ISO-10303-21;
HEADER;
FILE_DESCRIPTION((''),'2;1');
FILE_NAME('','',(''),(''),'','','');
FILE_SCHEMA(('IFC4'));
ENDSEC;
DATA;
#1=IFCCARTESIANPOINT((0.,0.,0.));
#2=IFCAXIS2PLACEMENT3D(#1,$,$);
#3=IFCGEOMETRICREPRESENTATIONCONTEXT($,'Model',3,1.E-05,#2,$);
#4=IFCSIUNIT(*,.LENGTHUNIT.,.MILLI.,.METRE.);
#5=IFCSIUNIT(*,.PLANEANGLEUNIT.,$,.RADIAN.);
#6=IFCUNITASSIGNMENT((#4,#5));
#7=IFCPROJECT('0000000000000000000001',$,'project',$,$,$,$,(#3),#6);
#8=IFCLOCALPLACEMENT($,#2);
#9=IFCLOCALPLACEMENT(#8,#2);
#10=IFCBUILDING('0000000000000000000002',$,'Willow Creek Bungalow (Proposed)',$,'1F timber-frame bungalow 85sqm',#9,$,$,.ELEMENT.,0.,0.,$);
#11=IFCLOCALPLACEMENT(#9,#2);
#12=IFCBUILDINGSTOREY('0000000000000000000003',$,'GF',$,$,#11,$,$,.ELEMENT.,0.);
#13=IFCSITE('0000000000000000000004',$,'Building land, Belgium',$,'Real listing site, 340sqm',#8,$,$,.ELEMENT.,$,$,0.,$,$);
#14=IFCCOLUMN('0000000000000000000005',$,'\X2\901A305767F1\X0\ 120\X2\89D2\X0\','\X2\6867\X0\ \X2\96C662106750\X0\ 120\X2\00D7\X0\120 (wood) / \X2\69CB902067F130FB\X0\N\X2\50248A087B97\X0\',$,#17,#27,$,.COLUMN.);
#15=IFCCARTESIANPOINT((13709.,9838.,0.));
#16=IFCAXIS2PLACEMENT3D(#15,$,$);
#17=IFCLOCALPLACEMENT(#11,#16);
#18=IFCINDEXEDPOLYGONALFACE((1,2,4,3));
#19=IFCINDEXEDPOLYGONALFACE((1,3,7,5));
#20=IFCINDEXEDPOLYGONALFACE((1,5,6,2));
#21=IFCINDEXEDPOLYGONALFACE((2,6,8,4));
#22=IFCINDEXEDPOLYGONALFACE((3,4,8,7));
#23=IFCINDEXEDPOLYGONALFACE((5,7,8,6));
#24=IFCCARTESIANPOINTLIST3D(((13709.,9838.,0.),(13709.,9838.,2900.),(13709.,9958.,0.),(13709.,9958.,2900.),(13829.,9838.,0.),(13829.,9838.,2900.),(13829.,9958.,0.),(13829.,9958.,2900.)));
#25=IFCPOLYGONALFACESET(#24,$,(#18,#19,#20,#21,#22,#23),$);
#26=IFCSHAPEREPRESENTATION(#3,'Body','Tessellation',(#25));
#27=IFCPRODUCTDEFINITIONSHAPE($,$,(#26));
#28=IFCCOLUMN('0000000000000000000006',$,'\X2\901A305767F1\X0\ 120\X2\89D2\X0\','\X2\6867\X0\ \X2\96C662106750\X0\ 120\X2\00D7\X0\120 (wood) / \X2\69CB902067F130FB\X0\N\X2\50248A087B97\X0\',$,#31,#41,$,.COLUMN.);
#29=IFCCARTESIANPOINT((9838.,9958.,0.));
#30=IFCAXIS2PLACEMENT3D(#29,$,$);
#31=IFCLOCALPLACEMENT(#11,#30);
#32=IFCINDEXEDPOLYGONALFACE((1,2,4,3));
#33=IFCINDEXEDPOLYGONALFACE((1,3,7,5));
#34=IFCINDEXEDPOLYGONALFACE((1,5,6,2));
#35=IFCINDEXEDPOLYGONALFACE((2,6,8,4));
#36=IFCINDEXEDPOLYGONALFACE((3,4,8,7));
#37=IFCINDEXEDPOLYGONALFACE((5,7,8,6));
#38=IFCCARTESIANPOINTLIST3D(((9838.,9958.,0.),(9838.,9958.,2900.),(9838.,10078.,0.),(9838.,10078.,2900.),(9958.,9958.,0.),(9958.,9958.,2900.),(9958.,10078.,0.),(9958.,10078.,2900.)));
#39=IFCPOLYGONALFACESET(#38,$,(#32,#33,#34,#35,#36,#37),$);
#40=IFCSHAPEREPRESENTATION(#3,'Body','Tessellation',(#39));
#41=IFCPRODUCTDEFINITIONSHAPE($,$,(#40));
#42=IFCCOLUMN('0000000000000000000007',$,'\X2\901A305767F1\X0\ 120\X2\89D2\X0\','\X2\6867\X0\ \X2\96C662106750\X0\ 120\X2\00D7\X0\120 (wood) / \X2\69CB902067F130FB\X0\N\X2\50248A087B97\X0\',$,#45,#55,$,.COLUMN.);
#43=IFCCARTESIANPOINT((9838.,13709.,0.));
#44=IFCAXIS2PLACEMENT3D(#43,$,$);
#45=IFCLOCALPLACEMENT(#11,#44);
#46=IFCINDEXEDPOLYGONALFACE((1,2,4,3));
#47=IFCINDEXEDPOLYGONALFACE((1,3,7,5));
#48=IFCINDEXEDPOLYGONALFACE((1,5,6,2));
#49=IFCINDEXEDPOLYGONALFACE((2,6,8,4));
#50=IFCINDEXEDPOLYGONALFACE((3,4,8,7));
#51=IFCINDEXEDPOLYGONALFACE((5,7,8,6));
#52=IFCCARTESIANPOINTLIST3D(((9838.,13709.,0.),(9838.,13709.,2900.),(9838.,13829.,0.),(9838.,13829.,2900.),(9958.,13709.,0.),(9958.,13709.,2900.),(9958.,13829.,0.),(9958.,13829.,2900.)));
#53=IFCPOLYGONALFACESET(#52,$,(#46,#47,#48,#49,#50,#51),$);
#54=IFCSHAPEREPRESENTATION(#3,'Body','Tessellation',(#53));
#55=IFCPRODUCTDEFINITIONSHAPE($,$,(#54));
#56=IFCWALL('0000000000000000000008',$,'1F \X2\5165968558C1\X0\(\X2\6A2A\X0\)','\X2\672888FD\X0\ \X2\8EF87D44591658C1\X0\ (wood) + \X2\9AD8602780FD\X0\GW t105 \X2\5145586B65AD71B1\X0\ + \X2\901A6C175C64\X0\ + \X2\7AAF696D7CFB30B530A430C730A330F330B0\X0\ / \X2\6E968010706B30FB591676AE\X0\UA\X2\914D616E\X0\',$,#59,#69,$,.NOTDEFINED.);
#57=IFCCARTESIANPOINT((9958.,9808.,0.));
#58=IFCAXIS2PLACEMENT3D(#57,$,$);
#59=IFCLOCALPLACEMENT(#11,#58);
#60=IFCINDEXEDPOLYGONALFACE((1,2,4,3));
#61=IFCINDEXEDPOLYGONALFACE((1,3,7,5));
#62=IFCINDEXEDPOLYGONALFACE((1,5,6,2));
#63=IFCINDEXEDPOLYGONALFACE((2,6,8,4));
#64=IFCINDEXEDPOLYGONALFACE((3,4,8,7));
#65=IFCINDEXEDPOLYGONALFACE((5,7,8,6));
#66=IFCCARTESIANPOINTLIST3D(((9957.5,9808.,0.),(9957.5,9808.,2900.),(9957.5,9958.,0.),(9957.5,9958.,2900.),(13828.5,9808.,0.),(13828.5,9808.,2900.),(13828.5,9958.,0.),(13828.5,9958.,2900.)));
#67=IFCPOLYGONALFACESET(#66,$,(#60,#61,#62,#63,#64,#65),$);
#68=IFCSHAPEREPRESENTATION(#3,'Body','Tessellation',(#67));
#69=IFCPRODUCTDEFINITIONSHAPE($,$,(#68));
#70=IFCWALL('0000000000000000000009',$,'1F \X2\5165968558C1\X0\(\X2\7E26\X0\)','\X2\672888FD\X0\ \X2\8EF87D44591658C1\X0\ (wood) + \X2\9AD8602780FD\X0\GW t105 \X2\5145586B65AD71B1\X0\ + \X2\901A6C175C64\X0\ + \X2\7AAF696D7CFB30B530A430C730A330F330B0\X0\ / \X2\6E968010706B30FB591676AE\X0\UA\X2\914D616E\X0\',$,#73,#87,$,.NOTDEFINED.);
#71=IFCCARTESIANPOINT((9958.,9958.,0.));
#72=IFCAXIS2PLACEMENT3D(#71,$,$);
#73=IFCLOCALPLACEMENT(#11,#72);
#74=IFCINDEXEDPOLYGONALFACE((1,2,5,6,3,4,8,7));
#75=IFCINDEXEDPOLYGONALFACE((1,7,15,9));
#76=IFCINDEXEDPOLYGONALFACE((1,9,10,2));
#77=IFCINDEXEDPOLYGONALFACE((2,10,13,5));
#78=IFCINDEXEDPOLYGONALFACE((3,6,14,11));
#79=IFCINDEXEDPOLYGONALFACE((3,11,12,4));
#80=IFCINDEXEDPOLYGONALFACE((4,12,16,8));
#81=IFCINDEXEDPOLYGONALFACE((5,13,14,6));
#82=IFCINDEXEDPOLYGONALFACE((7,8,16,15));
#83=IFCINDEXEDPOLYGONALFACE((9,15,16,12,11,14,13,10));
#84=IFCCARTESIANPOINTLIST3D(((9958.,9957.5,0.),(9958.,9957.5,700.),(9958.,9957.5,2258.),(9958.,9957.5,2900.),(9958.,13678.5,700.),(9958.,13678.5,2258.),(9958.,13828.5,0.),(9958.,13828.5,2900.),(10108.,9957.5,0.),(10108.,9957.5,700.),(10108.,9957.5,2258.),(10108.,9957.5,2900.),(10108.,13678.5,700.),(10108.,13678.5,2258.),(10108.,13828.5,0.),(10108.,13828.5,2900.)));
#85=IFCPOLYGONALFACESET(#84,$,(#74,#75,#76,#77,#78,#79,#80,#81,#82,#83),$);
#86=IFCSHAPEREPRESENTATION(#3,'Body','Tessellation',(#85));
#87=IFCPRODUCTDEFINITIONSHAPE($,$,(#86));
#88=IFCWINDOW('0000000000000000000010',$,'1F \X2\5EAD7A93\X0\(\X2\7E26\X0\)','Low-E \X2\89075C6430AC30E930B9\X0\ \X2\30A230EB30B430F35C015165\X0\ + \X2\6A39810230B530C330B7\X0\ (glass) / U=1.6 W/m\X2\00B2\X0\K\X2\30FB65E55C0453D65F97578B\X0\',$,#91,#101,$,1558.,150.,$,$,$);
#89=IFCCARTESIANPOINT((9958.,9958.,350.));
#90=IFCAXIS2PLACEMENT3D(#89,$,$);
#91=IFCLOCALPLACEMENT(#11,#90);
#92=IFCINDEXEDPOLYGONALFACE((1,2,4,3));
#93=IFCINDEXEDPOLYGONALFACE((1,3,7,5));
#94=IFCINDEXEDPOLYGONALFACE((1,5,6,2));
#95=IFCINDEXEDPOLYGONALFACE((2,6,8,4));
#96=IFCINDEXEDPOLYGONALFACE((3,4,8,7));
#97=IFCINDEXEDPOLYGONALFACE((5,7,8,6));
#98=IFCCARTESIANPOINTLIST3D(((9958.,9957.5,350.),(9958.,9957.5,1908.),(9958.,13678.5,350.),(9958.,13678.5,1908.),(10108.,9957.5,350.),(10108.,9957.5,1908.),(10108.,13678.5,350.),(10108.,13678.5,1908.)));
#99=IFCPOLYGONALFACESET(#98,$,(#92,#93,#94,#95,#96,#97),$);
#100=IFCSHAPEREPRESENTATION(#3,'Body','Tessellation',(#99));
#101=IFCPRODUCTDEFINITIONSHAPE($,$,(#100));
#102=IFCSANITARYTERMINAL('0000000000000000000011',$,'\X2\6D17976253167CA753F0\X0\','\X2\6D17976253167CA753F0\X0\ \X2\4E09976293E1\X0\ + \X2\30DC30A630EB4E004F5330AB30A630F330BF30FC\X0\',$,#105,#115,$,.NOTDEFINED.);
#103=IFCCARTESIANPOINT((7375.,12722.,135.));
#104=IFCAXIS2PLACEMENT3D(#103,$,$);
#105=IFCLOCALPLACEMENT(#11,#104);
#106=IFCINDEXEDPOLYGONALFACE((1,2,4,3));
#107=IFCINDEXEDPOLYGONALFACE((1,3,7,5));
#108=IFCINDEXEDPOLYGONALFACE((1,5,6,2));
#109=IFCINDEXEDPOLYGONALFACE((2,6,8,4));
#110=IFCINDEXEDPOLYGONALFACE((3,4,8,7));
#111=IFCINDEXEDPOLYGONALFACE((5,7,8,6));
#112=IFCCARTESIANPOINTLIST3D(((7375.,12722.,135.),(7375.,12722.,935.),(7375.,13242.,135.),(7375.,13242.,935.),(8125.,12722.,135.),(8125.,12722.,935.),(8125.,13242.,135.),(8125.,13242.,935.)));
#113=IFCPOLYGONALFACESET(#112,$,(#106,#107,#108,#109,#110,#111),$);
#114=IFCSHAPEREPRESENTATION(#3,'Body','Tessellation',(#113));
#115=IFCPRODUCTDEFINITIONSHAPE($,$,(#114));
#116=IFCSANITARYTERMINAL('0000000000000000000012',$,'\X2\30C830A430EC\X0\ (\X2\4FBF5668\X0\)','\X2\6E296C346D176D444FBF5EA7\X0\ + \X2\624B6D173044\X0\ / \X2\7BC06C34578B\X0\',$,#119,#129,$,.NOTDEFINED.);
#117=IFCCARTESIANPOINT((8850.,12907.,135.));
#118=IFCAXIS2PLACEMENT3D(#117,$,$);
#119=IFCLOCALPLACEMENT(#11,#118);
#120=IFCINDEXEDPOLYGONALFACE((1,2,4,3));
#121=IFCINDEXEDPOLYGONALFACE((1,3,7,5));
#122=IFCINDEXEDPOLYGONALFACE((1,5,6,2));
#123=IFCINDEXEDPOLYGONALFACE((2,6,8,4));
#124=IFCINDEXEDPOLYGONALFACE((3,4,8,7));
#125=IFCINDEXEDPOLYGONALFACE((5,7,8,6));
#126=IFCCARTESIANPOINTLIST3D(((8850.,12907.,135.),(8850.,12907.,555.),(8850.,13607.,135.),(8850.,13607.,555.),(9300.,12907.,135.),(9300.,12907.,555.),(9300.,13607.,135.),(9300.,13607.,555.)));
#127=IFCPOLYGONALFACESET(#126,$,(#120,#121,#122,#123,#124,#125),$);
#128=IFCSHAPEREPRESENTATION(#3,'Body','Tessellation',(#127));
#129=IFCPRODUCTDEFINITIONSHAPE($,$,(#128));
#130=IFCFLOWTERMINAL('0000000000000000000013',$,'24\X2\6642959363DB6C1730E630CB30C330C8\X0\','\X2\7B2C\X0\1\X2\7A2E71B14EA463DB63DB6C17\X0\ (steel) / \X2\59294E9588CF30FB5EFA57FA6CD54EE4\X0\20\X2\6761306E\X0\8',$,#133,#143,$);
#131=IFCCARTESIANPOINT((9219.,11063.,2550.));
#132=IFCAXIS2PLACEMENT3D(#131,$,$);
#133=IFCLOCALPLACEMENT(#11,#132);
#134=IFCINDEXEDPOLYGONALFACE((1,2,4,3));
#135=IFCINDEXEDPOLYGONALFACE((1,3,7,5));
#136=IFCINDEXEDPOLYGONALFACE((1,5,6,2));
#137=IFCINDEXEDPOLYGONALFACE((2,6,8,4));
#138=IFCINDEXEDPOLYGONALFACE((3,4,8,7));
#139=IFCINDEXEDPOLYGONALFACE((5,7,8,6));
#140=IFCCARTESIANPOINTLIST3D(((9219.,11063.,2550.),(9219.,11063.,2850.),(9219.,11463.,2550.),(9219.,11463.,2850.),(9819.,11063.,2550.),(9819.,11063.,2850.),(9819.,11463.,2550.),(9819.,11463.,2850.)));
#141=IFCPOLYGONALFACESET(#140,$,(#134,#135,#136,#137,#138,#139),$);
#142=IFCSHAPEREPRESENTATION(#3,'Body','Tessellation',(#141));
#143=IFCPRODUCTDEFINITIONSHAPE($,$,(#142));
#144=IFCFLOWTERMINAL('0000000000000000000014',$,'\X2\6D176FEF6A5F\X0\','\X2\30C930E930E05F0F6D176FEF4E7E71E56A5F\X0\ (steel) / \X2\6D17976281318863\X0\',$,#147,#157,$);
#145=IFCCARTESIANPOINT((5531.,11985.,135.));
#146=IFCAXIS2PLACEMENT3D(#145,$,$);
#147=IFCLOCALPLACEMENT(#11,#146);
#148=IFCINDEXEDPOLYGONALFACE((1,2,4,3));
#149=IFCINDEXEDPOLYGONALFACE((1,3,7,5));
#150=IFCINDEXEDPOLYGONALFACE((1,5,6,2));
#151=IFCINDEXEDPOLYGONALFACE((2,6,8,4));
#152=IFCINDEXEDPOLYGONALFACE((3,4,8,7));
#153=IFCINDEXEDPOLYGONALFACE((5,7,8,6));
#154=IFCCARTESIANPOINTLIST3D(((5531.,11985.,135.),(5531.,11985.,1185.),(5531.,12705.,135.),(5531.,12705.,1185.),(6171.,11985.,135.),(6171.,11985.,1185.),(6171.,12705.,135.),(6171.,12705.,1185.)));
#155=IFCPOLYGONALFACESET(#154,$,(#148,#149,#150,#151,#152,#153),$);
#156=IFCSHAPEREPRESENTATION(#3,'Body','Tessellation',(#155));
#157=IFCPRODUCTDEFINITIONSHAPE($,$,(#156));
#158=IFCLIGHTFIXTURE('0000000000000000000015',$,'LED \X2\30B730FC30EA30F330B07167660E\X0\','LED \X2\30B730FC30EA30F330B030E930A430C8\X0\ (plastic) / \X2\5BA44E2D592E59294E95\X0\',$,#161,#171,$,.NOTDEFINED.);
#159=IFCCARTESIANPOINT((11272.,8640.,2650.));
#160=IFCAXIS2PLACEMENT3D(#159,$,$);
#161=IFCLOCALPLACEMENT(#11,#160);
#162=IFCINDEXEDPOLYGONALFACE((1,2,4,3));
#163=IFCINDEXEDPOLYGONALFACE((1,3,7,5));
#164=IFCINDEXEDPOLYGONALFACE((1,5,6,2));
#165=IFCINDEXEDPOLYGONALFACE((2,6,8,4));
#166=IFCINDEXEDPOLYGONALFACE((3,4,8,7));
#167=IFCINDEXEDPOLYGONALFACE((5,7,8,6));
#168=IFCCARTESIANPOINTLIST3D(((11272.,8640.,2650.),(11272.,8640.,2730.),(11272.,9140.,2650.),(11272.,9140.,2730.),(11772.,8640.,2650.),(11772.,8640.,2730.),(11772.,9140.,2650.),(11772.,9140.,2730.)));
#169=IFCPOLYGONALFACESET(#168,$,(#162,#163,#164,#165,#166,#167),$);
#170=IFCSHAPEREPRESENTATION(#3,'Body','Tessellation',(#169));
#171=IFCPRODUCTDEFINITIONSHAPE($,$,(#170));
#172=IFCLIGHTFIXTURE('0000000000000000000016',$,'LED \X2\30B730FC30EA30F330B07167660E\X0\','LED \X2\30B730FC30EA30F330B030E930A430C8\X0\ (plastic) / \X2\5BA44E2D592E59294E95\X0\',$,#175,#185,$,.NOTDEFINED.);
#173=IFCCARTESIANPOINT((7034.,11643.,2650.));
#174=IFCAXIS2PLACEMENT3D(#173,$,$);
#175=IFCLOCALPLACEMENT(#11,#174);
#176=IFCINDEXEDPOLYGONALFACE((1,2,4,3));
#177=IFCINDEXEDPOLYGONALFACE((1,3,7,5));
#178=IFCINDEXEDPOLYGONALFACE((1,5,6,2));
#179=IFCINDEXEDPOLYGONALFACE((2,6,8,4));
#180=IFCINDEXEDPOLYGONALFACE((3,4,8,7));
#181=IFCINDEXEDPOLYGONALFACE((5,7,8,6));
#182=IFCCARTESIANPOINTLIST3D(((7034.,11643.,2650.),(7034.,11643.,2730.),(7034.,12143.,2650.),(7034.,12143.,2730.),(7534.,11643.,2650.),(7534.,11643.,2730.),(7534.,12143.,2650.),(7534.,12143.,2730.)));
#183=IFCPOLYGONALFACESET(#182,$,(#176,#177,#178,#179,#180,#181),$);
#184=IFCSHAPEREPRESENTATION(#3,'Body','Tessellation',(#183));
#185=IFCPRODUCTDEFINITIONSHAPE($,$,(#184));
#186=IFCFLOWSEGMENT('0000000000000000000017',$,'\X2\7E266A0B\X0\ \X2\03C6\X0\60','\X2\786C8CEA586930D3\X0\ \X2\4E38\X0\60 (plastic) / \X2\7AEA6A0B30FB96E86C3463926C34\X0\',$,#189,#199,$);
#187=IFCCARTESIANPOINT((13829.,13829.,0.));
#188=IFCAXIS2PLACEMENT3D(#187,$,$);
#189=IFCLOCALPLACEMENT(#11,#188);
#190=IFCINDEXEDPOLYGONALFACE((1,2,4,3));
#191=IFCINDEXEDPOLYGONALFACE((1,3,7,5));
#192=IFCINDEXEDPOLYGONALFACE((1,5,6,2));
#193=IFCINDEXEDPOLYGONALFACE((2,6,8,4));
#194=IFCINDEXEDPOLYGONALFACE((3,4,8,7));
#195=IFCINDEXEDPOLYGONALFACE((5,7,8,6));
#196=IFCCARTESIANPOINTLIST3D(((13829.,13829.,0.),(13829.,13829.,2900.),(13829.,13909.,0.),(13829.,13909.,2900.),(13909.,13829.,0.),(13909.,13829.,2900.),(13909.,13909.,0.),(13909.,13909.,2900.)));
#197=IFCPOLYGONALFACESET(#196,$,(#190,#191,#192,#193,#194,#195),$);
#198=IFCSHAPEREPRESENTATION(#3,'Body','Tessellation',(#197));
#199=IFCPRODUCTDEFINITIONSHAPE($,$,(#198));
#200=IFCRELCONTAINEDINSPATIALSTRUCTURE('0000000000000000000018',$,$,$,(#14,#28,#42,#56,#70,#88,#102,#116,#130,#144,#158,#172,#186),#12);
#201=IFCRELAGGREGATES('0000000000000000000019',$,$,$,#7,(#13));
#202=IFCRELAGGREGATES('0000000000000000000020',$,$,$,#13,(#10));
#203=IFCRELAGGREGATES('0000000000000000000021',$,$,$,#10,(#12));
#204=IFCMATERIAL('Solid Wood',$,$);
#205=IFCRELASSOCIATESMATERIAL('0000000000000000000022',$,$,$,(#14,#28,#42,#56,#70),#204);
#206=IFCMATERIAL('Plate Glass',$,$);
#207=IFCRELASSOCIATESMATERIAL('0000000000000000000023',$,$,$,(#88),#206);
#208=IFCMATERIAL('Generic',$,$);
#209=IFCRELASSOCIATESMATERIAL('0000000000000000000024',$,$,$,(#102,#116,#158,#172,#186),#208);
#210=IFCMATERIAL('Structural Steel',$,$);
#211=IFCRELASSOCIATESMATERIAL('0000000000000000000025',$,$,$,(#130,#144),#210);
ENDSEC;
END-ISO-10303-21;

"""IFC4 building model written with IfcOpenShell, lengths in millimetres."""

from ifc_helpers import new_model, si_unit, frame, frame_2d, origin, place, context, project, spatial, rectangle, extrude, material, element, fill, save


model = new_model("IFC4")

# Units and contexts
model_context = context("Model", 3, precision=1e-05, world=origin())
ifc_project = project(units=[si_unit("LENGTHUNIT", "METRE", prefix="MILLI"), si_unit("PLANEANGLEUNIT", "RADIAN")], contexts=[model_context])

# Site, building, storey
site_placement = place(None, origin())
site = spatial("IfcSite", under=ifc_project, at=site_placement, Name="Building land, Belgium", ObjectType="Real listing site, 340sqm", CompositionType="ELEMENT", RefElevation=0.0)
building_placement = place(site_placement, origin())
building = spatial("IfcBuilding", under=site, at=building_placement, Name="Willow Creek Bungalow (Proposed)", ObjectType="1F timber-frame bungalow 85sqm", CompositionType="ELEMENT", ElevationOfRefHeight=0.0, ElevationOfTerrain=0.0)
storey_placement = place(building_placement, origin())
storey = spatial("IfcBuildingStorey", under=building, at=storey_placement, Name="GF", CompositionType="ELEMENT", Elevation=0.0)

# Columns
ifc_material_1 = material(Name="Solid Wood")
column_1_placement = place(storey_placement, frame((13709.0, 9838.0, 0.0)))
element("IfcColumn", 1, at=column_1_placement, inside=storey, material=ifc_material_1, Name="通し柱 120角", Description="桧 集成材 120×120 (wood) / 構造柱・N値計算", PredefinedType="COLUMN", context=model_context, shape_type="SweptSolid", body=[
    extrude(rectangle(XDim=120.0, YDim=120.0, at=frame_2d((60.0, 60.0))), frame((13709.0, 9838.0, 0.0)), (0.0, 0.0, 1.0), 2900.0),
])
column_2_placement = place(storey_placement, frame((9838.0, 9958.0, 0.0)))
element("IfcColumn", 2, at=column_2_placement, inside=storey, material=ifc_material_1, Name="通し柱 120角", Description="桧 集成材 120×120 (wood) / 構造柱・N値計算", PredefinedType="COLUMN", context=model_context, shape_type="SweptSolid", body=[
    extrude(rectangle(XDim=120.0, YDim=120.0, at=frame_2d((60.0, 60.0))), frame((9838.0, 9958.0, 0.0)), (0.0, 0.0, 1.0), 2900.0),
])
column_3_placement = place(storey_placement, frame((9838.0, 13709.0, 0.0)))
element("IfcColumn", 3, at=column_3_placement, inside=storey, material=ifc_material_1, Name="通し柱 120角", Description="桧 集成材 120×120 (wood) / 構造柱・N値計算", PredefinedType="COLUMN", context=model_context, shape_type="SweptSolid", body=[
    extrude(rectangle(XDim=120.0, YDim=120.0, at=frame_2d((60.0, 60.0))), frame((9838.0, 13709.0, 0.0)), (0.0, 0.0, 1.0), 2900.0),
])

# Wall
wall_1_placement = place(storey_placement, frame((9958.0, 9808.0, 0.0)))
element("IfcWall", 4, at=wall_1_placement, inside=storey, material=ifc_material_1, Name="1F 入隅壁(横)", Description="木製 軸組外壁 (wood) + 高性能GW t105 充填断熱 + 通気層 + 窯業系サイディング / 準耐火・外皮UA配慮", PredefinedType="NOTDEFINED", context=model_context, shape_type="SweptSolid", body=[
    extrude(rectangle(XDim=3871.0, YDim=150.0, at=frame_2d((1935.0, 75.0))), frame((9958.0, 9808.0, 0.0)), (0.0, 0.0, 1.0), 2900.0),
])

# Wall, opening, window
wall_2_placement = place(storey_placement, frame((9958.0, 9958.0, 0.0)))
wall_2 = element("IfcWall", 5, at=wall_2_placement, inside=storey, material=ifc_material_1, Name="1F 入隅壁(縦)", Description="木製 軸組外壁 (wood) + 高性能GW t105 充填断熱 + 通気層 + 窯業系サイディング / 準耐火・外皮UA配慮", PredefinedType="NOTDEFINED", context=model_context, shape_type="SweptSolid", body=[
    extrude(rectangle(XDim=150.0, YDim=3871.0, at=frame_2d((75.0, 1935.0))), frame((9958.0, 9958.0, 0.0)), (0.0, 0.0, 1.0), 2900.0),
])
opening_placement = place(storey_placement, frame((9958.0, 9958.0, 350.0)))
opening = element("IfcOpeningElement", 6, at=opening_placement, cuts=wall_2, PredefinedType="NOTDEFINED", context=model_context, shape_type="SweptSolid", body=[
    extrude(rectangle(XDim=150.0, YDim=3721.0, at=frame_2d((75.0, 1860.0))), frame((9958.0, 9958.0, 350.0)), (0.0, 0.0, 1.0), 1558.0),
])
ifc_material_2 = material(Name="Plate Glass")
window_placement = place(storey_placement, frame((9958.0, 9958.0, 350.0)))
window = element("IfcWindow", 7, at=window_placement, inside=storey, material=ifc_material_2, Name="1F 庭窓(縦)", Description="Low-E 複層ガラス アルゴン封入 + 樹脂サッシ (glass) / U=1.6 W/m²K・日射取得型", OverallHeight=1558.0, OverallWidth=150.0, context=model_context, shape_type="SweptSolid", body=[
    extrude(rectangle(XDim=150.0, YDim=3721.0, at=frame_2d((75.0, 1860.0))), frame((9958.0, 9958.0, 350.0)), (0.0, 0.0, 1.0), 1558.0),
])
fill(opening, window)

# Sanitary terminals
ifc_material_3 = material(Name="Generic")
sanitary_terminal_1_placement = place(storey_placement, frame((7375.0, 12722.0, 135.0)))
element("IfcSanitaryTerminal", 8, at=sanitary_terminal_1_placement, inside=storey, material=ifc_material_3, Name="洗面化粧台", Description="洗面化粧台 三面鏡 + ボウル一体カウンター", PredefinedType="NOTDEFINED", context=model_context, shape_type="SweptSolid", body=[
    extrude(rectangle(XDim=750.0, YDim=520.0, at=frame_2d((375.0, 260.0))), frame((7375.0, 12722.0, 135.0)), (0.0, 0.0, 1.0), 800.0),
])
sanitary_terminal_2_placement = place(storey_placement, frame((8850.0, 12907.0, 135.0)))
element("IfcSanitaryTerminal", 9, at=sanitary_terminal_2_placement, inside=storey, material=ifc_material_3, Name="トイレ (便器)", Description="温水洗浄便座 + 手洗い / 節水型", PredefinedType="NOTDEFINED", context=model_context, shape_type="SweptSolid", body=[
    extrude(rectangle(XDim=450.0, YDim=700.0, at=frame_2d((225.0, 350.0))), frame((8850.0, 12907.0, 135.0)), (0.0, 0.0, 1.0), 420.0),
])

# Flow terminals
ifc_material_4 = material(Name="Structural Steel")
flow_terminal_1_placement = place(storey_placement, frame((9219.0, 11063.0, 2550.0)))
element("IfcFlowTerminal", 10, at=flow_terminal_1_placement, inside=storey, material=ifc_material_4, Name="24時間換気ユニット", Description="第1種熱交換換気 (steel) / 天井裏・建基法令20条の8", context=model_context, shape_type="SweptSolid", body=[
    extrude(rectangle(XDim=600.0, YDim=400.0, at=frame_2d((300.0, 200.0))), frame((9219.0, 11063.0, 2550.0)), (0.0, 0.0, 1.0), 300.0),
])
flow_terminal_2_placement = place(storey_placement, frame((5531.0, 11985.0, 135.0)))
element("IfcFlowTerminal", 11, at=flow_terminal_2_placement, inside=storey, material=ifc_material_4, Name="洗濯機", Description="ドラム式洗濯乾燥機 (steel) / 洗面脱衣", context=model_context, shape_type="SweptSolid", body=[
    extrude(rectangle(XDim=640.0, YDim=720.0, at=frame_2d((320.0, 360.0))), frame((5531.0, 11985.0, 135.0)), (0.0, 0.0, 1.0), 1050.0),
])

# Light fixtures
light_fixture_1_placement = place(storey_placement, frame((11272.0, 8640.0, 2650.0)))
element("IfcLightFixture", 12, at=light_fixture_1_placement, inside=storey, material=ifc_material_3, Name="LED シーリング照明", Description="LED シーリングライト (plastic) / 室中央天井", PredefinedType="NOTDEFINED", context=model_context, shape_type="SweptSolid", body=[
    extrude(rectangle(XDim=500.0, YDim=500.0, at=frame_2d((250.0, 250.0))), frame((11272.0, 8640.0, 2650.0)), (0.0, 0.0, 1.0), 80.0),
])
light_fixture_2_placement = place(storey_placement, frame((7034.0, 11643.0, 2650.0)))
element("IfcLightFixture", 13, at=light_fixture_2_placement, inside=storey, material=ifc_material_3, Name="LED シーリング照明", Description="LED シーリングライト (plastic) / 室中央天井", PredefinedType="NOTDEFINED", context=model_context, shape_type="SweptSolid", body=[
    extrude(rectangle(XDim=500.0, YDim=500.0, at=frame_2d((250.0, 250.0))), frame((7034.0, 11643.0, 2650.0)), (0.0, 0.0, 1.0), 80.0),
])

# Flow segment
flow_segment_placement = place(storey_placement, frame((13829.0, 13829.0, 0.0)))
element("IfcFlowSegment", 14, at=flow_segment_placement, inside=storey, material=ifc_material_3, Name="縦樋 φ60", Description="硬質塩ビ 丸60 (plastic) / 竪樋・雨水排水", context=model_context, shape_type="SweptSolid", body=[
    extrude(rectangle(XDim=80.0, YDim=80.0, at=frame_2d((40.0, 40.0))), frame((13829.0, 13829.0, 0.0)), (0.0, 0.0, 1.0), 2900.0),
])

save(model, "model.ifc")
